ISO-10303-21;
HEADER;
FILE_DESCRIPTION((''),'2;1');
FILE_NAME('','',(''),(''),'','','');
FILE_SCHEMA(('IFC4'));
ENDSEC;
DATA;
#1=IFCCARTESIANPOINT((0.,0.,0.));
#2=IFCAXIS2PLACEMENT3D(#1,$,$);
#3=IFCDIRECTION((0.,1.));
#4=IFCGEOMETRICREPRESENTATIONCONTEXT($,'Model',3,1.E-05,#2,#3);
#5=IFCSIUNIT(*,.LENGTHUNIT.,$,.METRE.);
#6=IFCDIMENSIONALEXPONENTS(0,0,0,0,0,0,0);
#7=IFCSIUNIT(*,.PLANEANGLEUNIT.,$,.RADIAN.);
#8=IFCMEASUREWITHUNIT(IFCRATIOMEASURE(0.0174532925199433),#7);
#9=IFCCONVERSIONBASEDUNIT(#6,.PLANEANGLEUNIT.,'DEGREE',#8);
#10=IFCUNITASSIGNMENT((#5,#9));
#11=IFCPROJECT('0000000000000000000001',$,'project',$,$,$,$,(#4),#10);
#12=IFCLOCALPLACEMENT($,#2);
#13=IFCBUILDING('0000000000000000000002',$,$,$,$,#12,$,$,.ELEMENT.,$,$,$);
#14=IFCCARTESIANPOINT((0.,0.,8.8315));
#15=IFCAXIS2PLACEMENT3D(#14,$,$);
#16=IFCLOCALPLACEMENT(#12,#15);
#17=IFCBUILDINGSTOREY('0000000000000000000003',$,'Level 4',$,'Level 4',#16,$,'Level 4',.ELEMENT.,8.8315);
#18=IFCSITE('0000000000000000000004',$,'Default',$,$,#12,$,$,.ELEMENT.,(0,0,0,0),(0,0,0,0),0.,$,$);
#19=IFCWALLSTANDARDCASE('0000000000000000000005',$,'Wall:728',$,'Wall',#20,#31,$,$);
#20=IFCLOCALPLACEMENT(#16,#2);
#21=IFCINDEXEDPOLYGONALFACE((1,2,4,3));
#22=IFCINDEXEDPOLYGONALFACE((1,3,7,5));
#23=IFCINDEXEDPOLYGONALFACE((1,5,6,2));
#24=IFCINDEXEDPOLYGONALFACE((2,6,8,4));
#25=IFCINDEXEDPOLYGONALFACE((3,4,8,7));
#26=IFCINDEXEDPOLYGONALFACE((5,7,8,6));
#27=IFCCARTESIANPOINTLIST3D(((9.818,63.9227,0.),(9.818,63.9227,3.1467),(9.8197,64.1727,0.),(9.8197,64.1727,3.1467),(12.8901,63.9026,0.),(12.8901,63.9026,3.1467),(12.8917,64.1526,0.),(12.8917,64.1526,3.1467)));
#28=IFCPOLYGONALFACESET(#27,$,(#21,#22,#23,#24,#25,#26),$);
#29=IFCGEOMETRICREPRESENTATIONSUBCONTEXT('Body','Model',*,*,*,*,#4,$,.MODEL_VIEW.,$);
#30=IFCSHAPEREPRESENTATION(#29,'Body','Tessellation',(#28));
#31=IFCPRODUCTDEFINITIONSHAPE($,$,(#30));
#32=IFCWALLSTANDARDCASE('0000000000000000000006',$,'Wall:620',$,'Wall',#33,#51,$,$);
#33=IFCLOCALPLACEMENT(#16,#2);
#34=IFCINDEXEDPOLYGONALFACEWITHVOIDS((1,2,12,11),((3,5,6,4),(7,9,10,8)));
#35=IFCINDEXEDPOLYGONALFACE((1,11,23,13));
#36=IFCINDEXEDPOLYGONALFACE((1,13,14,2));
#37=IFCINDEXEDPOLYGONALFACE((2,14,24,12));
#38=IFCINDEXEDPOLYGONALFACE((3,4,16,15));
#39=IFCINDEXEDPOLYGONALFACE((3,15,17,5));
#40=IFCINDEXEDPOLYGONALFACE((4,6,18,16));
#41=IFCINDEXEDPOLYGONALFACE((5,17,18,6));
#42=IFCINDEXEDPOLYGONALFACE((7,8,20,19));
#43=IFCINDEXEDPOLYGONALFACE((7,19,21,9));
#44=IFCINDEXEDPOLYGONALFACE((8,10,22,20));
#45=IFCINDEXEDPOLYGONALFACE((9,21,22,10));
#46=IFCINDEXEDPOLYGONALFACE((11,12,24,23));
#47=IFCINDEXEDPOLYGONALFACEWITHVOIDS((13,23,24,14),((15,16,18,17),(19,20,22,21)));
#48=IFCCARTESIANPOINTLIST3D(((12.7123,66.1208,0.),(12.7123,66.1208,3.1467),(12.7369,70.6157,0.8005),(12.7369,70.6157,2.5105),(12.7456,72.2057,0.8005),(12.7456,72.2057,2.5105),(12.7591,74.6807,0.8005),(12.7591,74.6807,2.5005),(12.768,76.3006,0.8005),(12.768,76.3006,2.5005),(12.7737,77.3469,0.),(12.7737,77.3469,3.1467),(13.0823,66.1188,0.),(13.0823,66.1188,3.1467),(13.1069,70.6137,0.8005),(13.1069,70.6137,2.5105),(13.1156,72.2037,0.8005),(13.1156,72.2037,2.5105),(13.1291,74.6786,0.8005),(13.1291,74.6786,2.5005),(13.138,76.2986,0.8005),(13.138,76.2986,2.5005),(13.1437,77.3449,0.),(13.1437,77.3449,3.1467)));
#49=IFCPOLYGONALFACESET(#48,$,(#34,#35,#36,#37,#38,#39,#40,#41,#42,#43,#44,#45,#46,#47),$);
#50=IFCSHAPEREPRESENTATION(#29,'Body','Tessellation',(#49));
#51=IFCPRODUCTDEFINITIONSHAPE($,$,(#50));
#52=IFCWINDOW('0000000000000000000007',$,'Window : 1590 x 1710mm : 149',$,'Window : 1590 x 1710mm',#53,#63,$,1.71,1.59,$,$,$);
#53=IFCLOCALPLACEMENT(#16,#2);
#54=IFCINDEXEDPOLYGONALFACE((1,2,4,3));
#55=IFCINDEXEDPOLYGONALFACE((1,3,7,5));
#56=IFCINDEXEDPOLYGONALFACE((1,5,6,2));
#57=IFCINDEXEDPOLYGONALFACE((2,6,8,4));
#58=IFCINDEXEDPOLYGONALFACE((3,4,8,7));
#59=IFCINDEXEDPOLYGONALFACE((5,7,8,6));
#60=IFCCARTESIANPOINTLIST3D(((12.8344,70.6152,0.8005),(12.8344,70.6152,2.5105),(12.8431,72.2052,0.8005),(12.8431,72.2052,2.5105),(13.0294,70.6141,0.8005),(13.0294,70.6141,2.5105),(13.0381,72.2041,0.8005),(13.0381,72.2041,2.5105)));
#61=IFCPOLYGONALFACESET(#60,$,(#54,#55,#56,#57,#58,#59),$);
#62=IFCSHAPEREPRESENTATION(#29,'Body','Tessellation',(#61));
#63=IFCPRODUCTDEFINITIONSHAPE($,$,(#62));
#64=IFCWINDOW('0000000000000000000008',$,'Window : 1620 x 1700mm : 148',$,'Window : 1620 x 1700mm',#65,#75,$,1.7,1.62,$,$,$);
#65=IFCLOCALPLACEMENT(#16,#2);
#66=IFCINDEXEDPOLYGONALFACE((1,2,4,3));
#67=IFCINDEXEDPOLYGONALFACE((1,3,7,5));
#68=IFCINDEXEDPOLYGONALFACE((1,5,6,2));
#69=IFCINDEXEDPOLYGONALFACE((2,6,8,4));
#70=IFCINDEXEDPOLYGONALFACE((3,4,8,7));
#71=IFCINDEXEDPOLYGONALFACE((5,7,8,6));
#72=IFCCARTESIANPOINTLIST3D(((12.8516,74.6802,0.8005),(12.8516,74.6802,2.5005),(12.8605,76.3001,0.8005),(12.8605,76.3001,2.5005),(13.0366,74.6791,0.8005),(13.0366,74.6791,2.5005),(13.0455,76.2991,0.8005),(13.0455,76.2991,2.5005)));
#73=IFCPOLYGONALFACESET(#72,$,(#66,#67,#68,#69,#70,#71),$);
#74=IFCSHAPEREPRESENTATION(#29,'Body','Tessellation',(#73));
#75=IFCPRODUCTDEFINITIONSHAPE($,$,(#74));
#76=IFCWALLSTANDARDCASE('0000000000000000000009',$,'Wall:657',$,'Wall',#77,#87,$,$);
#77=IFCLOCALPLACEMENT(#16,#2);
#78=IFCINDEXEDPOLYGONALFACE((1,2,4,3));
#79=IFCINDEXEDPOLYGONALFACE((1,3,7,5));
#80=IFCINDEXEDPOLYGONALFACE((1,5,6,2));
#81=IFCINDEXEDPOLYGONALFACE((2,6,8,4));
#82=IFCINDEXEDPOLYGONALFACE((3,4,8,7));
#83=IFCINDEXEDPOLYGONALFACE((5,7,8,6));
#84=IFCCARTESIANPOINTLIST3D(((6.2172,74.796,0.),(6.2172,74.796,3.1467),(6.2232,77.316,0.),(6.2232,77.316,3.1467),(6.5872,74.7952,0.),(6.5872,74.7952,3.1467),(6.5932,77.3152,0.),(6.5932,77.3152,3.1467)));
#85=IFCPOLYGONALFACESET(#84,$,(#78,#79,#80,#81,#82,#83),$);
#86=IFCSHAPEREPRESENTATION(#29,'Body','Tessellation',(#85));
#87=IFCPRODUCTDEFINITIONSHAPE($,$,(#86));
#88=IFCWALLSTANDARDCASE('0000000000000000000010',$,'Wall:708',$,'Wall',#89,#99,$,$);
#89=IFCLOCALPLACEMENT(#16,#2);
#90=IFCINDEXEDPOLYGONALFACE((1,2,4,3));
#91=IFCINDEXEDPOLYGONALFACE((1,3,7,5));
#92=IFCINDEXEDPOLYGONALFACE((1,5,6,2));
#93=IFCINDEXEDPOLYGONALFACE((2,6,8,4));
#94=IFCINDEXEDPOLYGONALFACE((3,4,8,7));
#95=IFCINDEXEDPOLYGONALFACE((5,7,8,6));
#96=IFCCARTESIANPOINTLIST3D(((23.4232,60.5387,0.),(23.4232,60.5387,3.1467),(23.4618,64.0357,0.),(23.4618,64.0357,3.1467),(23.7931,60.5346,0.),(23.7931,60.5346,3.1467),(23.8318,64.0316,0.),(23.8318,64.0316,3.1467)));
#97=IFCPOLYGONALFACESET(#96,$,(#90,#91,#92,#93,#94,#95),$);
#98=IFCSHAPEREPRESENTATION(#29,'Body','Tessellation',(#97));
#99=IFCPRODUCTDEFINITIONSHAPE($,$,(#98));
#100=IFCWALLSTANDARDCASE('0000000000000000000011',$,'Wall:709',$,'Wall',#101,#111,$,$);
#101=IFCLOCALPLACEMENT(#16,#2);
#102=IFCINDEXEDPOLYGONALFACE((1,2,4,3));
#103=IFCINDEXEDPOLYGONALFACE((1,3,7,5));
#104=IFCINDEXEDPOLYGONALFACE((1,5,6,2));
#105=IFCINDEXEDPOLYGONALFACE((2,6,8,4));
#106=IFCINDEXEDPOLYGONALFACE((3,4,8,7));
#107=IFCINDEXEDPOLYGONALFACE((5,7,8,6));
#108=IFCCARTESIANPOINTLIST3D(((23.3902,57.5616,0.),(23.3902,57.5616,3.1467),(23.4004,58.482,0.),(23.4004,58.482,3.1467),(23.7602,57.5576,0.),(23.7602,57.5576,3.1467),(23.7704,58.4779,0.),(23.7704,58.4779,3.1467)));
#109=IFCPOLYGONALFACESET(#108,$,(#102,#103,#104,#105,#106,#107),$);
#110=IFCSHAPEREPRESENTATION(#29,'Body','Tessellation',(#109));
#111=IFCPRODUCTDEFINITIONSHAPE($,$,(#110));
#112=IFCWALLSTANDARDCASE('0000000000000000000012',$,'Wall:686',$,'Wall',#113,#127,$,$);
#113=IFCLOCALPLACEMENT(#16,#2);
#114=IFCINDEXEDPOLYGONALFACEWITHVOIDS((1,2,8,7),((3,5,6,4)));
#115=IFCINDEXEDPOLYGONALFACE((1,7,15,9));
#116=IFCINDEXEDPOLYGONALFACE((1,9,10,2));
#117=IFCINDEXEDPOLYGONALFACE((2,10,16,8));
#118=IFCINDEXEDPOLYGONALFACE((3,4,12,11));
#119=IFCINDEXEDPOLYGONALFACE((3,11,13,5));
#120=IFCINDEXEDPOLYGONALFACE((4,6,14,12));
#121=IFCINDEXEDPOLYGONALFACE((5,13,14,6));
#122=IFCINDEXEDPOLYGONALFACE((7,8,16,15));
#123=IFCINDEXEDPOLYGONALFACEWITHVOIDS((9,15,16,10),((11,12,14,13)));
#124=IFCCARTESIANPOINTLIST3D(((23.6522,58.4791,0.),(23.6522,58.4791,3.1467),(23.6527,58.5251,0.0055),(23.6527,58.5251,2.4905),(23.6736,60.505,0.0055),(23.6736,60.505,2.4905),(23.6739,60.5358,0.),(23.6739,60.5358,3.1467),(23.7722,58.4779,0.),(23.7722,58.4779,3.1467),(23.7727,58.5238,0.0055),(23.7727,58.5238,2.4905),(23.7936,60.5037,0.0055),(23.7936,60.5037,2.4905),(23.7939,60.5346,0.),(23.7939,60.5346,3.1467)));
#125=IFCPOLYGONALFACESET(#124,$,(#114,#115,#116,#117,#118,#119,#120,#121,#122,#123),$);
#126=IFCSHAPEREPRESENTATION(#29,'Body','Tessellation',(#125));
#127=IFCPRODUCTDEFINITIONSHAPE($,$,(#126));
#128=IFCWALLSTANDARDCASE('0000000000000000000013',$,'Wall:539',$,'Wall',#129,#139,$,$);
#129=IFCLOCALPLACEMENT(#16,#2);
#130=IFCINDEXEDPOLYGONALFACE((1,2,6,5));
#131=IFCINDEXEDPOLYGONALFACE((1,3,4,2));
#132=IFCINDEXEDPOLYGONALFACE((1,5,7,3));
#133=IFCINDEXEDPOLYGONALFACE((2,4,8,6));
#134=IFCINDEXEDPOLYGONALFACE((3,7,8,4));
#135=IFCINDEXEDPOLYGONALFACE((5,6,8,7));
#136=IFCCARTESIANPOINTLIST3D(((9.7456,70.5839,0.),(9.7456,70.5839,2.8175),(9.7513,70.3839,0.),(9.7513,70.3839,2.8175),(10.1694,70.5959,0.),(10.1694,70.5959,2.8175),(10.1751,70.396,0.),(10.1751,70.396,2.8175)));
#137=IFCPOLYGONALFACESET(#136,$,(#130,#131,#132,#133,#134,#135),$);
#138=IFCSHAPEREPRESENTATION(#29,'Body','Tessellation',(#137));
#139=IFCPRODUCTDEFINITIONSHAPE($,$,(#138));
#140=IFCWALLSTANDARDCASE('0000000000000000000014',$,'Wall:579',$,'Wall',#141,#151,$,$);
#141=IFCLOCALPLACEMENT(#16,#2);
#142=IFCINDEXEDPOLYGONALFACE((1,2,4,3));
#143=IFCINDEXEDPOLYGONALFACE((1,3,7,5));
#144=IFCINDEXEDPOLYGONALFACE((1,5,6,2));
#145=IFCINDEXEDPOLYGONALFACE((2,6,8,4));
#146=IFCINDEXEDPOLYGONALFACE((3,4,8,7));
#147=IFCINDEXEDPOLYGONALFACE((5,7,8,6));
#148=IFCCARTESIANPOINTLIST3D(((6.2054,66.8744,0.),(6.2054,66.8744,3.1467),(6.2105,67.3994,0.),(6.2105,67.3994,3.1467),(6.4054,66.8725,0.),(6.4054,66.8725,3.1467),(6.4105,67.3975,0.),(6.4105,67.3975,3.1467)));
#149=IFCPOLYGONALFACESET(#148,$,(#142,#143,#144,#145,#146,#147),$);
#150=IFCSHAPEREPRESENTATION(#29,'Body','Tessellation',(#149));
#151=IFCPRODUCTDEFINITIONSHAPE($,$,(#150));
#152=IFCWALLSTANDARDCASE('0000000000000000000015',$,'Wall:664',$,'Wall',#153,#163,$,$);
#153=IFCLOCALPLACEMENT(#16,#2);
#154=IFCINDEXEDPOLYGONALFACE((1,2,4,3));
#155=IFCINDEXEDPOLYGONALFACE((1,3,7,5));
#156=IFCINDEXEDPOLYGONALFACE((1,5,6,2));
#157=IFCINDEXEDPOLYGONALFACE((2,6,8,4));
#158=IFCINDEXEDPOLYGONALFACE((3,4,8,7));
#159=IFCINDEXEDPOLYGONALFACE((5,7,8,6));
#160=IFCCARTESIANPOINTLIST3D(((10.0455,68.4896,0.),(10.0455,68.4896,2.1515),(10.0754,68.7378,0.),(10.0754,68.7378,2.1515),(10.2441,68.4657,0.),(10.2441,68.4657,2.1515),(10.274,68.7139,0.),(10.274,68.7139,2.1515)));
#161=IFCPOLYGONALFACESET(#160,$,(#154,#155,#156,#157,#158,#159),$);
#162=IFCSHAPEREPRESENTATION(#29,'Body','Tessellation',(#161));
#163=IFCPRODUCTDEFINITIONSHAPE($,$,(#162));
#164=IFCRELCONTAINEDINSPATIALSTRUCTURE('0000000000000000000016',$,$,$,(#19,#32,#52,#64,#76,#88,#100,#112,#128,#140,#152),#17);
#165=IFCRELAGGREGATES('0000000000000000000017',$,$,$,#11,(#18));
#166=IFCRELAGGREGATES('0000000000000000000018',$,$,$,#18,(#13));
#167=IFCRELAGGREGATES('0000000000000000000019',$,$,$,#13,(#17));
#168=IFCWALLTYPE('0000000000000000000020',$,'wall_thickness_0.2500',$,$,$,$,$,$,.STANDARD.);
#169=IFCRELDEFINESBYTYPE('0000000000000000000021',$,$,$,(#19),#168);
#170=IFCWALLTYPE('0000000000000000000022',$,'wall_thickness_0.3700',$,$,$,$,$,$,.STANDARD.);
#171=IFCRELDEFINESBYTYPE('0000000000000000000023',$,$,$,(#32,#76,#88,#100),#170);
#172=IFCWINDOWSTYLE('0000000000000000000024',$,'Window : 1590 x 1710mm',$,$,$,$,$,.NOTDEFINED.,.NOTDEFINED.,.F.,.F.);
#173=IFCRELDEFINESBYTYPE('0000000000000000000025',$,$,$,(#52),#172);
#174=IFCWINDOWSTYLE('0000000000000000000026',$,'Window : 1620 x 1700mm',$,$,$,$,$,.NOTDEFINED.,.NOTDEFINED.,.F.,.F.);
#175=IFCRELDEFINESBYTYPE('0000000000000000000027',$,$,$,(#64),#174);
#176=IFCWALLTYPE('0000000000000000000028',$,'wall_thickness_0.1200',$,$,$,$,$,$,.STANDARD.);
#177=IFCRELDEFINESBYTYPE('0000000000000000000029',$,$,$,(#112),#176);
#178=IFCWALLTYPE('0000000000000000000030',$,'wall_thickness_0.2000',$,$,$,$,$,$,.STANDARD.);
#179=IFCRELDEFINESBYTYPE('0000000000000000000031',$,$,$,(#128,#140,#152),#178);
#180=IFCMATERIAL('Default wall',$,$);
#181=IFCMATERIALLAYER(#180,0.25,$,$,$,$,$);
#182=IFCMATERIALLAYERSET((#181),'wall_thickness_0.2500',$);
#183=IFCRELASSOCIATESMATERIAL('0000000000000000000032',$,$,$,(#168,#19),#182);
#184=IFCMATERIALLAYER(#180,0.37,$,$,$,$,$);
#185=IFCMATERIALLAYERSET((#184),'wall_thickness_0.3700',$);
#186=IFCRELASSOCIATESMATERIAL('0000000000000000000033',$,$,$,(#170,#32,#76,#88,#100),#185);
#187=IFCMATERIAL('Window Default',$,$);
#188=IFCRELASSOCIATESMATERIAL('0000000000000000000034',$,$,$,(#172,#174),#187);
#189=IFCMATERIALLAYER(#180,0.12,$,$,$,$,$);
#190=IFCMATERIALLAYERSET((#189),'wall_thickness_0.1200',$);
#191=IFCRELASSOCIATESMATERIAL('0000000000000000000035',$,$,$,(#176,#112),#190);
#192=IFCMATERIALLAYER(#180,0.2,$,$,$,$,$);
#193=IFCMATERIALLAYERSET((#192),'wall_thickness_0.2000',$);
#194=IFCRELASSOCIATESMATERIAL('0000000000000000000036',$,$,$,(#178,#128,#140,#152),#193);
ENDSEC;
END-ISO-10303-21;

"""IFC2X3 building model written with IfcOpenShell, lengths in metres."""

from ifc_helpers import new_model, entity, si_unit, converted_unit, direction, frame, frame_2d, origin, origin_2d_with_axis, place, context, subcontext, project, spatial, polyline, rectangle, outline, extrude, source, transform, mapped, material, layer, layer_set, layer_usage, type_object, type_shapes, element, fill, save


model = new_model("IFC2X3")

# Units and contexts
model_context = context("Model", 3, precision=1e-05, world=origin(), true_north=direction((0.0, 1.0)))
body_context = subcontext(model_context, "Body", "Model", "MODEL_VIEW")
ifc_project = project(units=[si_unit("LENGTHUNIT", "METRE"), converted_unit("PLANEANGLEUNIT", "DEGREE", entity("IfcRatioMeasure", 0.0174532925199433), si_unit("PLANEANGLEUNIT", "RADIAN"), dimensions=[0, 0, 0, 0, 0, 0, 0])], contexts=[model_context])

# Site, building, storey
placement_1 = place(None, origin())
site = spatial("IfcSite", under=ifc_project, at=placement_1, Name="Default", CompositionType="ELEMENT", RefLatitude=(0, 0, 0, 0), RefLongitude=(0, 0, 0, 0), RefElevation=0.0)
building = spatial("IfcBuilding", under=site, at=placement_1, CompositionType="ELEMENT")
storey_placement = place(placement_1, frame((0.0, 0.0, 8.8315)))
storey = spatial("IfcBuildingStorey", under=building, at=storey_placement, Name="Level 4", ObjectType="Level 4", LongName="Level 4", CompositionType="ELEMENT", Elevation=8.8315)

# Shared definitions
ifc_material_1 = material(Name="Default wall")
ifc_material_2 = material(Name="Window Default")

# Shared definitions
ifc_layer_1 = layer(ifc_material_1, 0.25)
ifc_layer_set_1 = layer_set([ifc_layer_1], Name="wall_thickness_0.2500")
ifc_layer_usage_1 = layer_usage(ifc_layer_set_1, "AXIS2", "POSITIVE", -0.125)
wall_type_1 = type_object("IfcWallType", Name="wall_thickness_0.2500", PredefinedType="STANDARD", material=ifc_layer_set_1)

# Wall
wall_1_placement = place(storey_placement, frame((9.8189, 64.0477, 0.0), z_axis=(0.0, 0.0, 1.0), x_axis=(0.999979, -0.006554, 0.0)))
element("IfcWallStandardCase", 1, at=wall_1_placement, inside=storey, type_object=wall_type_1, material=ifc_layer_usage_1, Name="Wall:728", ObjectType="Wall", context=body_context, shape_type="SweptSolid", body=[
    extrude(outline(polyline([(3.0721, -0.125), (3.0721, 0.125), (0.0, 0.125), (0.0, -0.125), (3.0721, -0.125)])), origin(), (0.0, 0.0, 1.0), 3.1467),
])

# Wall, openings, windows
ifc_layer_2 = layer(ifc_material_1, 0.37)
ifc_layer_set_2 = layer_set([ifc_layer_2], Name="wall_thickness_0.3700")
ifc_layer_usage_2 = layer_usage(ifc_layer_set_2, "AXIS2", "POSITIVE", -0.185)
wall_type_2 = type_object("IfcWallType", Name="wall_thickness_0.3700", PredefinedType="STANDARD", material=ifc_layer_set_2)
wall_2_placement = place(storey_placement, frame((12.9587, 77.3459, 0.0), z_axis=(0.0, 0.0, 1.0), x_axis=(-0.005466, -0.999985, 0.0)))
wall_2 = element("IfcWallStandardCase", 2, at=wall_2_placement, inside=storey, type_object=wall_type_2, material=ifc_layer_usage_2, Name="Wall:620", ObjectType="Wall", context=body_context, shape_type="SweptSolid", body=[
    extrude(outline(polyline([(11.2263, -0.185), (11.2263, 0.185), (0.0, 0.185), (0.0, -0.185), (11.2263, -0.185)])), origin(), (0.0, 0.0, 1.0), 3.1467),
])
opening_1_placement = place(wall_2_placement, frame((1.0463, -0.185, 0.8005)))
opening_1 = element("IfcOpeningElement", 3, at=opening_1_placement, cuts=wall_2, ObjectType="Opening", context=body_context, shape_type="SweptSolid", body=[
    extrude(rectangle(XDim=1.62, YDim=1.7, at=frame_2d((0.85, 0.81), x_axis=(0.0, 1.0))), frame((0.0, 0.0, 0.0), z_axis=(0.0, 1.0, 0.0), x_axis=(0.0, 0.0, 1.0)), (0.0, 0.0, 1.0), 0.37),
])
opening_2_placement = place(wall_2_placement, frame((5.1413, -0.185, 0.8005)))
opening_2 = element("IfcOpeningElement", 4, at=opening_2_placement, cuts=wall_2, ObjectType="Opening", context=body_context, shape_type="SweptSolid", body=[
    extrude(rectangle(XDim=1.59, YDim=1.71, at=frame_2d((0.855, 0.795), x_axis=(0.0, 1.0))), frame((0.0, 0.0, 0.0), z_axis=(0.0, 1.0, 0.0), x_axis=(0.0, 0.0, 1.0)), (0.0, 0.0, 1.0), 0.37),
])
window_style_1 = type_object("IfcWindowStyle", Name="Window : 1590 x 1710mm", ConstructionType="NOTDEFINED", OperationType="NOTDEFINED", ParameterTakesPrecedence=False, Sizeable=False, material=ifc_material_2)
shared_shape_1 = source(origin(), body_context, "Body", "SweptSolid", [
    extrude(rectangle(XDim=0.195, YDim=1.59, at=origin_2d_with_axis()), frame((0.795, 0.195, 0.0), z_axis=(0.0, 0.0, 1.0), x_axis=(0.0, 1.0, 0.0)), (0.0, 0.0, 1.0), 1.71),
])
type_shapes(window_style_1, [shared_shape_1])
window_1_placement = place(opening_2_placement, origin())
window_1 = element("IfcWindow", 5, at=window_1_placement, inside=storey, type_object=window_style_1, Name="Window : 1590 x 1710mm : 149", ObjectType="Window : 1590 x 1710mm", OverallHeight=1.71, OverallWidth=1.59, context=body_context, shape_type="MappedRepresentation", body=[
    mapped(shared_shape_1, transform((0.0, 0.0, 0.0), scale=1.0)),
])
fill(opening_2, window_1)
window_style_2 = type_object("IfcWindowStyle", Name="Window : 1620 x 1700mm", ConstructionType="NOTDEFINED", OperationType="NOTDEFINED", ParameterTakesPrecedence=False, Sizeable=False, material=ifc_material_2)
shared_shape_2 = source(origin(), body_context, "Body", "SweptSolid", [
    extrude(rectangle(XDim=0.185, YDim=1.62, at=origin_2d_with_axis()), frame((0.81, 0.185, 0.0), z_axis=(0.0, 0.0, 1.0), x_axis=(0.0, 1.0, 0.0)), (0.0, 0.0, 1.0), 1.7),
])
type_shapes(window_style_2, [shared_shape_2])
window_2_placement = place(opening_1_placement, origin())
window_2 = element("IfcWindow", 6, at=window_2_placement, inside=storey, type_object=window_style_2, Name="Window : 1620 x 1700mm : 148", ObjectType="Window : 1620 x 1700mm", OverallHeight=1.7, OverallWidth=1.62, context=body_context, shape_type="MappedRepresentation", body=[
    mapped(shared_shape_2, transform((0.0, 0.0, 0.0), scale=1.0)),
])
fill(opening_1, window_2)

# Walls
wall_3_placement = place(storey_placement, frame((6.4082, 77.3156, 0.0), z_axis=(0.0, 0.0, 1.0), x_axis=(-0.002362, -0.999997, 0.0)))
element("IfcWallStandardCase", 7, at=wall_3_placement, inside=storey, type_object=wall_type_2, material=ifc_layer_usage_2, Name="Wall:657", ObjectType="Wall", context=body_context, shape_type="SweptSolid", body=[
    extrude(outline(polyline([(2.52, -0.185), (2.52, 0.185), (0.0, 0.185), (0.0, -0.185), (2.52, -0.185)])), origin(), (0.0, 0.0, 1.0), 3.1467),
])
wall_4_placement = place(storey_placement, frame((23.6468, 64.0337, 0.0), z_axis=(0.0, 0.0, 1.0), x_axis=(-0.011058, -0.999939, 0.0)))
element("IfcWallStandardCase", 8, at=wall_4_placement, inside=storey, type_object=wall_type_2, material=ifc_layer_usage_2, Name="Wall:708", ObjectType="Wall", context=body_context, shape_type="SweptSolid", body=[
    extrude(outline(polyline([(3.4973, -0.185), (3.4973, 0.185), (0.0, 0.185), (0.0, -0.185), (3.4973, -0.185)])), origin(), (0.0, 0.0, 1.0), 3.1467),
])
wall_5_placement = place(storey_placement, frame((23.5854, 58.4799, 0.0), z_axis=(0.0, 0.0, 1.0), x_axis=(-0.011058, -0.999939, 0.0)))
element("IfcWallStandardCase", 9, at=wall_5_placement, inside=storey, type_object=wall_type_2, material=ifc_layer_usage_2, Name="Wall:709", ObjectType="Wall", context=body_context, shape_type="SweptSolid", body=[
    extrude(outline(polyline([(0.9204, -0.185), (0.9204, 0.185), (0.0, 0.185), (0.0, -0.185), (0.9204, -0.185)])), origin(), (0.0, 0.0, 1.0), 3.1467),
])

# Wall, opening
ifc_layer_3 = layer(ifc_material_1, 0.12)
ifc_layer_set_3 = layer_set([ifc_layer_3], Name="wall_thickness_0.1200")
ifc_layer_usage_3 = layer_usage(ifc_layer_set_3, "AXIS2", "POSITIVE", -0.06)
wall_type_3 = type_object("IfcWallType", Name="wall_thickness_0.1200", PredefinedType="STANDARD", material=ifc_layer_set_3)
wall_6_placement = place(storey_placement, frame((23.7339, 60.5352, 0.0), z_axis=(0.0, 0.0, 1.0), x_axis=(-0.010533, -0.999945, 0.0)))
wall_6 = element("IfcWallStandardCase", 10, at=wall_6_placement, inside=storey, type_object=wall_type_3, material=ifc_layer_usage_3, Name="Wall:686", ObjectType="Wall", context=body_context, shape_type="SweptSolid", body=[
    extrude(outline(polyline([(2.0568, -0.06), (2.0568, 0.06), (0.0, 0.06), (0.0, -0.06), (2.0568, -0.06)])), origin(), (0.0, 0.0, 1.0), 3.1467),
])
opening_3_placement = place(wall_6_placement, frame((0.0308, -0.06, 0.0055)))
element("IfcOpeningElement", 11, at=opening_3_placement, cuts=wall_6, ObjectType="Opening", context=body_context, shape_type="SweptSolid", body=[
    extrude(rectangle(XDim=1.98, YDim=2.485, at=frame_2d((1.2425, 0.99), x_axis=(0.0, 1.0))), frame((0.0, 0.0, 0.0), z_axis=(0.0, 1.0, 0.0), x_axis=(0.0, 0.0, 1.0)), (0.0, 0.0, 1.0), 0.12),
])

# Walls
ifc_layer_4 = layer(ifc_material_1, 0.2)
ifc_layer_set_4 = layer_set([ifc_layer_4], Name="wall_thickness_0.2000")
ifc_layer_usage_4 = layer_usage(ifc_layer_set_4, "AXIS2", "POSITIVE", -0.1)
wall_type_4 = type_object("IfcWallType", Name="wall_thickness_0.2000", PredefinedType="STANDARD", material=ifc_layer_set_4)
wall_7_placement = place(storey_placement, frame((10.1723, 70.496, 0.0), z_axis=(0.0, 0.0, 1.0), x_axis=(-0.999595, -0.028447, 0.0)))
element("IfcWallStandardCase", 12, at=wall_7_placement, inside=storey, type_object=wall_type_4, material=ifc_layer_usage_4, Name="Wall:539", ObjectType="Wall", context=body_context, shape_type="SweptSolid", body=[
    extrude(outline(polyline([(0.424, -0.1), (0.424, 0.1), (0.0, 0.1), (0.0, -0.1), (0.424, -0.1)])), origin(), (0.0, 0.0, 1.0), 2.8175),
])
wall_8_placement = place(storey_placement, frame((6.3105, 67.3984, 0.0), z_axis=(0.0, 0.0, 1.0), x_axis=(-0.009642, -0.999954, 0.0)))
element("IfcWallStandardCase", 13, at=wall_8_placement, inside=storey, type_object=wall_type_4, material=ifc_layer_usage_4, Name="Wall:579", ObjectType="Wall", context=body_context, shape_type="SweptSolid", body=[
    extrude(outline(polyline([(0.525, -0.1), (0.525, 0.1), (0.0, 0.1), (0.0, -0.1), (0.525, -0.1)])), origin(), (0.0, 0.0, 1.0), 3.1467),
])
wall_9_placement = place(storey_placement, frame((10.1747, 68.7258, 0.0), z_axis=(0.0, 0.0, 1.0), x_axis=(-0.119598, -0.992822, 0.0)))
element("IfcWallStandardCase", 14, at=wall_9_placement, inside=storey, type_object=wall_type_4, material=ifc_layer_usage_4, Name="Wall:664", ObjectType="Wall", context=body_context, shape_type="SweptSolid", body=[
    extrude(outline(polyline([(0.25, -0.1), (0.25, 0.1), (0.0, 0.1), (0.0, -0.1), (0.25, -0.1)])), origin(), (0.0, 0.0, 1.0), 2.1515),
])

save(model, "model.ifc")
